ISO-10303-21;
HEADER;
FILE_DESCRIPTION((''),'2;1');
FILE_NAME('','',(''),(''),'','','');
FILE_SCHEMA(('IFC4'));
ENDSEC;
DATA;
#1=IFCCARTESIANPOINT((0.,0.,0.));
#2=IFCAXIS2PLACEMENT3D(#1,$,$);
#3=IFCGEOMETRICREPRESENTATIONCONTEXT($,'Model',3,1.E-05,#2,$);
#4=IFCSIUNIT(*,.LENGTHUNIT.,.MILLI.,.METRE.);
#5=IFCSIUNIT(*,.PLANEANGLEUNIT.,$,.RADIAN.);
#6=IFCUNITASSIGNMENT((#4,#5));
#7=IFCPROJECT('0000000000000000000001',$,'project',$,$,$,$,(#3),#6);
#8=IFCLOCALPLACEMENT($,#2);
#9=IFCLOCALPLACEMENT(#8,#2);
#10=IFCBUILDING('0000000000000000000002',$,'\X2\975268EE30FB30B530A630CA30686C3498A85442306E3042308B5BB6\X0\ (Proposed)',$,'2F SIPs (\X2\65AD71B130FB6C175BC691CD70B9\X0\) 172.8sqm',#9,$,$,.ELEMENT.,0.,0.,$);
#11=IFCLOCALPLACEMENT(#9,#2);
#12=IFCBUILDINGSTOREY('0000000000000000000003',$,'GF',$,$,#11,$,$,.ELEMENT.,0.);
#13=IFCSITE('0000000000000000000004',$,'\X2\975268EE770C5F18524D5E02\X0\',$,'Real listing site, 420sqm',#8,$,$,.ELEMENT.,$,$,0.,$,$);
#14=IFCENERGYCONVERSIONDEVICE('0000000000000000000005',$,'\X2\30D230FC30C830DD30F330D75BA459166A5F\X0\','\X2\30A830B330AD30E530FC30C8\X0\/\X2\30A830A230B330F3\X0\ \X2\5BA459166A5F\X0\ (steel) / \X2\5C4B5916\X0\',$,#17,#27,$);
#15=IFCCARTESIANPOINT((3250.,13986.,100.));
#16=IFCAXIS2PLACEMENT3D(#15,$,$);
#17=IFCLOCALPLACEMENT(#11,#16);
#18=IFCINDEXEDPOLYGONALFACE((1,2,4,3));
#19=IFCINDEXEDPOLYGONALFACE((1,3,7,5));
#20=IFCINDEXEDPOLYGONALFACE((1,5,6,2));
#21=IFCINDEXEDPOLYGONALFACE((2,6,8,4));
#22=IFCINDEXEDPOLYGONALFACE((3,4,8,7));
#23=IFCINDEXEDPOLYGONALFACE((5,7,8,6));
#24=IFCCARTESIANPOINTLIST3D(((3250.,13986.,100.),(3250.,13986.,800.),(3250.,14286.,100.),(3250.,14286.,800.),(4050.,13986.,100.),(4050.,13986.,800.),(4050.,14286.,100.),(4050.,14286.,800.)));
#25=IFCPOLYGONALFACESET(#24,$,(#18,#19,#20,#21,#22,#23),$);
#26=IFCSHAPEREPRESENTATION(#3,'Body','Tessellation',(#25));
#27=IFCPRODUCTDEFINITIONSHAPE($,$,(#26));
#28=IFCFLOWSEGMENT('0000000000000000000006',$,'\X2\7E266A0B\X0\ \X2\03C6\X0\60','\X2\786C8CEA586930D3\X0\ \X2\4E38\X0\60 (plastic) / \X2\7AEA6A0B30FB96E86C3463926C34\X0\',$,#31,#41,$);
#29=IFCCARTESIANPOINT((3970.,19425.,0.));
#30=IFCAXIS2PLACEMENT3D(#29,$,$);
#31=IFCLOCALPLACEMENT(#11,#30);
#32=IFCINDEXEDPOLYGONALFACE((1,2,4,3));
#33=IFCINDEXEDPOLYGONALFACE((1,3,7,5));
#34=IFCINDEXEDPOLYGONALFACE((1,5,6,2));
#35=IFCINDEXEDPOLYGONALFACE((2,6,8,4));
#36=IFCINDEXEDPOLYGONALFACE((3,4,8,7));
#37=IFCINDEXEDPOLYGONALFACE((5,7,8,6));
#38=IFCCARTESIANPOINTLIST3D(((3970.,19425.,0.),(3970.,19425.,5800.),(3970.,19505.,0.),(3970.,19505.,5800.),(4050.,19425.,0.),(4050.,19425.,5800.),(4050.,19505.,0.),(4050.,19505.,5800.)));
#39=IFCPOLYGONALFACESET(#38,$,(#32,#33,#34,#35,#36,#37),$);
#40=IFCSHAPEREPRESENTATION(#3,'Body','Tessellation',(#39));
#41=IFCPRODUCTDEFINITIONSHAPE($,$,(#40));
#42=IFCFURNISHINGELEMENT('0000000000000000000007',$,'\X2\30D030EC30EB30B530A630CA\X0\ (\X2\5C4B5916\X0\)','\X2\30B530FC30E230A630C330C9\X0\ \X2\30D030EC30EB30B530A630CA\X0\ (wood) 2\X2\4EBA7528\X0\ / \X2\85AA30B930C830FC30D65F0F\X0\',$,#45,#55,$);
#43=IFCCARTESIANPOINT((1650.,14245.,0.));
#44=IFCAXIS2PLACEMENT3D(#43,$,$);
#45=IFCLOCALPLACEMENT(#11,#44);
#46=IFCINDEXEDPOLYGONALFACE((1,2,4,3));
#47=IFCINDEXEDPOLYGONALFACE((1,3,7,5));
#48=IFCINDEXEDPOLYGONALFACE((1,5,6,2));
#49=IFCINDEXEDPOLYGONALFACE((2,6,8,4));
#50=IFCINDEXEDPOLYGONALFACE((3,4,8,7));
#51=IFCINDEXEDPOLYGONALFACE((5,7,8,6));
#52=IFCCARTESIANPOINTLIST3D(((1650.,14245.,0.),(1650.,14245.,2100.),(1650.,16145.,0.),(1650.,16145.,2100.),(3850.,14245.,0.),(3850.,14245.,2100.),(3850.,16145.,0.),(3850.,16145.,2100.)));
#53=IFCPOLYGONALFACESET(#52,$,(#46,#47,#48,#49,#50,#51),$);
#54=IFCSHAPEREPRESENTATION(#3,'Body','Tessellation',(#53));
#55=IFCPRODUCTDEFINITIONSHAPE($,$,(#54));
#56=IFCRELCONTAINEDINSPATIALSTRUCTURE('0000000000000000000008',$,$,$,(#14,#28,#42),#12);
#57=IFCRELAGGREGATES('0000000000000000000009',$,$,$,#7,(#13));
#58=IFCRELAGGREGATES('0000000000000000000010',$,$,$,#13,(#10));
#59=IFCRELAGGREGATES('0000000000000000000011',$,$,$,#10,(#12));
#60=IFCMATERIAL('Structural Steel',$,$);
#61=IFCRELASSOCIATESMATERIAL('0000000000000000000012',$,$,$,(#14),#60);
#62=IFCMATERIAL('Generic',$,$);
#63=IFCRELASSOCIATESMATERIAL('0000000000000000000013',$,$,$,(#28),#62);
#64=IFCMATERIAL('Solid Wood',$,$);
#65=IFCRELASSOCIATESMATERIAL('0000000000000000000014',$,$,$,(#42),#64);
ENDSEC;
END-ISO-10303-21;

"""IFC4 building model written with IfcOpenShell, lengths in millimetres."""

from ifc_helpers import new_model, si_unit, frame, frame_2d, origin, place, context, project, spatial, rectangle, extrude, material, element, save


model = new_model("IFC4")

# Units and contexts
model_context = context("Model", 3, precision=1e-05, world=origin())
ifc_project = project(units=[si_unit("LENGTHUNIT", "METRE", prefix="MILLI"), si_unit("PLANEANGLEUNIT", "RADIAN")], contexts=[model_context])

# Site, building, storey
site_placement = place(None, origin())
site = spatial("IfcSite", under=ifc_project, at=site_placement, Name="青森県弘前市", ObjectType="Real listing site, 420sqm", CompositionType="ELEMENT", RefElevation=0.0)
building_placement = place(site_placement, origin())
building = spatial("IfcBuilding", under=site, at=building_placement, Name="青森・サウナと水風呂のある家 (Proposed)", ObjectType="2F SIPs (断熱・気密重点) 172.8sqm", CompositionType="ELEMENT", ElevationOfRefHeight=0.0, ElevationOfTerrain=0.0)
storey_placement = place(building_placement, origin())
storey = spatial("IfcBuildingStorey", under=building, at=storey_placement, Name="GF", CompositionType="ELEMENT", Elevation=0.0)

# Shared definitions
ifc_material_1 = material(Name="Solid Wood")

# Shared definitions
ifc_material_2 = material(Name="Generic")

# Energy conversion device
ifc_material_3 = material(Name="Structural Steel")
energy_conversion_device_placement = place(storey_placement, frame((3250.0, 13986.0, 100.0)))
element("IfcEnergyConversionDevice", 1, at=energy_conversion_device_placement, inside=storey, material=ifc_material_3, Name="ヒートポンプ室外機", Description="エコキュート/エアコン 室外機 (steel) / 屋外", context=model_context, shape_type="SweptSolid", body=[
    extrude(rectangle(XDim=800.0, YDim=300.0, at=frame_2d((400.0, 150.0))), frame((3250.0, 13986.0, 100.0)), (0.0, 0.0, 1.0), 700.0),
])

# Flow segment
flow_segment_placement = place(storey_placement, frame((3970.0, 19425.0, 0.0)))
element("IfcFlowSegment", 2, at=flow_segment_placement, inside=storey, material=ifc_material_2, Name="縦樋 φ60", Description="硬質塩ビ 丸60 (plastic) / 竪樋・雨水排水", context=model_context, shape_type="SweptSolid", body=[
    extrude(rectangle(XDim=80.0, YDim=80.0, at=frame_2d((40.0, 40.0))), frame((3970.0, 19425.0, 0.0)), (0.0, 0.0, 1.0), 5800.0),
])

# Furnishing element
furnishing_placement = place(storey_placement, frame((1650.0, 14245.0, 0.0)))
element("IfcFurnishingElement", 3, at=furnishing_placement, inside=storey, material=ifc_material_1, Name="バレルサウナ (屋外)", Description="サーモウッド バレルサウナ (wood) 2人用 / 薪ストーブ式", context=model_context, shape_type="SweptSolid", body=[
    extrude(rectangle(XDim=2200.0, YDim=1900.0, at=frame_2d((1100.0, 950.0))), frame((1650.0, 14245.0, 0.0)), (0.0, 0.0, 1.0), 2100.0),
])

save(model, "model.ifc")
